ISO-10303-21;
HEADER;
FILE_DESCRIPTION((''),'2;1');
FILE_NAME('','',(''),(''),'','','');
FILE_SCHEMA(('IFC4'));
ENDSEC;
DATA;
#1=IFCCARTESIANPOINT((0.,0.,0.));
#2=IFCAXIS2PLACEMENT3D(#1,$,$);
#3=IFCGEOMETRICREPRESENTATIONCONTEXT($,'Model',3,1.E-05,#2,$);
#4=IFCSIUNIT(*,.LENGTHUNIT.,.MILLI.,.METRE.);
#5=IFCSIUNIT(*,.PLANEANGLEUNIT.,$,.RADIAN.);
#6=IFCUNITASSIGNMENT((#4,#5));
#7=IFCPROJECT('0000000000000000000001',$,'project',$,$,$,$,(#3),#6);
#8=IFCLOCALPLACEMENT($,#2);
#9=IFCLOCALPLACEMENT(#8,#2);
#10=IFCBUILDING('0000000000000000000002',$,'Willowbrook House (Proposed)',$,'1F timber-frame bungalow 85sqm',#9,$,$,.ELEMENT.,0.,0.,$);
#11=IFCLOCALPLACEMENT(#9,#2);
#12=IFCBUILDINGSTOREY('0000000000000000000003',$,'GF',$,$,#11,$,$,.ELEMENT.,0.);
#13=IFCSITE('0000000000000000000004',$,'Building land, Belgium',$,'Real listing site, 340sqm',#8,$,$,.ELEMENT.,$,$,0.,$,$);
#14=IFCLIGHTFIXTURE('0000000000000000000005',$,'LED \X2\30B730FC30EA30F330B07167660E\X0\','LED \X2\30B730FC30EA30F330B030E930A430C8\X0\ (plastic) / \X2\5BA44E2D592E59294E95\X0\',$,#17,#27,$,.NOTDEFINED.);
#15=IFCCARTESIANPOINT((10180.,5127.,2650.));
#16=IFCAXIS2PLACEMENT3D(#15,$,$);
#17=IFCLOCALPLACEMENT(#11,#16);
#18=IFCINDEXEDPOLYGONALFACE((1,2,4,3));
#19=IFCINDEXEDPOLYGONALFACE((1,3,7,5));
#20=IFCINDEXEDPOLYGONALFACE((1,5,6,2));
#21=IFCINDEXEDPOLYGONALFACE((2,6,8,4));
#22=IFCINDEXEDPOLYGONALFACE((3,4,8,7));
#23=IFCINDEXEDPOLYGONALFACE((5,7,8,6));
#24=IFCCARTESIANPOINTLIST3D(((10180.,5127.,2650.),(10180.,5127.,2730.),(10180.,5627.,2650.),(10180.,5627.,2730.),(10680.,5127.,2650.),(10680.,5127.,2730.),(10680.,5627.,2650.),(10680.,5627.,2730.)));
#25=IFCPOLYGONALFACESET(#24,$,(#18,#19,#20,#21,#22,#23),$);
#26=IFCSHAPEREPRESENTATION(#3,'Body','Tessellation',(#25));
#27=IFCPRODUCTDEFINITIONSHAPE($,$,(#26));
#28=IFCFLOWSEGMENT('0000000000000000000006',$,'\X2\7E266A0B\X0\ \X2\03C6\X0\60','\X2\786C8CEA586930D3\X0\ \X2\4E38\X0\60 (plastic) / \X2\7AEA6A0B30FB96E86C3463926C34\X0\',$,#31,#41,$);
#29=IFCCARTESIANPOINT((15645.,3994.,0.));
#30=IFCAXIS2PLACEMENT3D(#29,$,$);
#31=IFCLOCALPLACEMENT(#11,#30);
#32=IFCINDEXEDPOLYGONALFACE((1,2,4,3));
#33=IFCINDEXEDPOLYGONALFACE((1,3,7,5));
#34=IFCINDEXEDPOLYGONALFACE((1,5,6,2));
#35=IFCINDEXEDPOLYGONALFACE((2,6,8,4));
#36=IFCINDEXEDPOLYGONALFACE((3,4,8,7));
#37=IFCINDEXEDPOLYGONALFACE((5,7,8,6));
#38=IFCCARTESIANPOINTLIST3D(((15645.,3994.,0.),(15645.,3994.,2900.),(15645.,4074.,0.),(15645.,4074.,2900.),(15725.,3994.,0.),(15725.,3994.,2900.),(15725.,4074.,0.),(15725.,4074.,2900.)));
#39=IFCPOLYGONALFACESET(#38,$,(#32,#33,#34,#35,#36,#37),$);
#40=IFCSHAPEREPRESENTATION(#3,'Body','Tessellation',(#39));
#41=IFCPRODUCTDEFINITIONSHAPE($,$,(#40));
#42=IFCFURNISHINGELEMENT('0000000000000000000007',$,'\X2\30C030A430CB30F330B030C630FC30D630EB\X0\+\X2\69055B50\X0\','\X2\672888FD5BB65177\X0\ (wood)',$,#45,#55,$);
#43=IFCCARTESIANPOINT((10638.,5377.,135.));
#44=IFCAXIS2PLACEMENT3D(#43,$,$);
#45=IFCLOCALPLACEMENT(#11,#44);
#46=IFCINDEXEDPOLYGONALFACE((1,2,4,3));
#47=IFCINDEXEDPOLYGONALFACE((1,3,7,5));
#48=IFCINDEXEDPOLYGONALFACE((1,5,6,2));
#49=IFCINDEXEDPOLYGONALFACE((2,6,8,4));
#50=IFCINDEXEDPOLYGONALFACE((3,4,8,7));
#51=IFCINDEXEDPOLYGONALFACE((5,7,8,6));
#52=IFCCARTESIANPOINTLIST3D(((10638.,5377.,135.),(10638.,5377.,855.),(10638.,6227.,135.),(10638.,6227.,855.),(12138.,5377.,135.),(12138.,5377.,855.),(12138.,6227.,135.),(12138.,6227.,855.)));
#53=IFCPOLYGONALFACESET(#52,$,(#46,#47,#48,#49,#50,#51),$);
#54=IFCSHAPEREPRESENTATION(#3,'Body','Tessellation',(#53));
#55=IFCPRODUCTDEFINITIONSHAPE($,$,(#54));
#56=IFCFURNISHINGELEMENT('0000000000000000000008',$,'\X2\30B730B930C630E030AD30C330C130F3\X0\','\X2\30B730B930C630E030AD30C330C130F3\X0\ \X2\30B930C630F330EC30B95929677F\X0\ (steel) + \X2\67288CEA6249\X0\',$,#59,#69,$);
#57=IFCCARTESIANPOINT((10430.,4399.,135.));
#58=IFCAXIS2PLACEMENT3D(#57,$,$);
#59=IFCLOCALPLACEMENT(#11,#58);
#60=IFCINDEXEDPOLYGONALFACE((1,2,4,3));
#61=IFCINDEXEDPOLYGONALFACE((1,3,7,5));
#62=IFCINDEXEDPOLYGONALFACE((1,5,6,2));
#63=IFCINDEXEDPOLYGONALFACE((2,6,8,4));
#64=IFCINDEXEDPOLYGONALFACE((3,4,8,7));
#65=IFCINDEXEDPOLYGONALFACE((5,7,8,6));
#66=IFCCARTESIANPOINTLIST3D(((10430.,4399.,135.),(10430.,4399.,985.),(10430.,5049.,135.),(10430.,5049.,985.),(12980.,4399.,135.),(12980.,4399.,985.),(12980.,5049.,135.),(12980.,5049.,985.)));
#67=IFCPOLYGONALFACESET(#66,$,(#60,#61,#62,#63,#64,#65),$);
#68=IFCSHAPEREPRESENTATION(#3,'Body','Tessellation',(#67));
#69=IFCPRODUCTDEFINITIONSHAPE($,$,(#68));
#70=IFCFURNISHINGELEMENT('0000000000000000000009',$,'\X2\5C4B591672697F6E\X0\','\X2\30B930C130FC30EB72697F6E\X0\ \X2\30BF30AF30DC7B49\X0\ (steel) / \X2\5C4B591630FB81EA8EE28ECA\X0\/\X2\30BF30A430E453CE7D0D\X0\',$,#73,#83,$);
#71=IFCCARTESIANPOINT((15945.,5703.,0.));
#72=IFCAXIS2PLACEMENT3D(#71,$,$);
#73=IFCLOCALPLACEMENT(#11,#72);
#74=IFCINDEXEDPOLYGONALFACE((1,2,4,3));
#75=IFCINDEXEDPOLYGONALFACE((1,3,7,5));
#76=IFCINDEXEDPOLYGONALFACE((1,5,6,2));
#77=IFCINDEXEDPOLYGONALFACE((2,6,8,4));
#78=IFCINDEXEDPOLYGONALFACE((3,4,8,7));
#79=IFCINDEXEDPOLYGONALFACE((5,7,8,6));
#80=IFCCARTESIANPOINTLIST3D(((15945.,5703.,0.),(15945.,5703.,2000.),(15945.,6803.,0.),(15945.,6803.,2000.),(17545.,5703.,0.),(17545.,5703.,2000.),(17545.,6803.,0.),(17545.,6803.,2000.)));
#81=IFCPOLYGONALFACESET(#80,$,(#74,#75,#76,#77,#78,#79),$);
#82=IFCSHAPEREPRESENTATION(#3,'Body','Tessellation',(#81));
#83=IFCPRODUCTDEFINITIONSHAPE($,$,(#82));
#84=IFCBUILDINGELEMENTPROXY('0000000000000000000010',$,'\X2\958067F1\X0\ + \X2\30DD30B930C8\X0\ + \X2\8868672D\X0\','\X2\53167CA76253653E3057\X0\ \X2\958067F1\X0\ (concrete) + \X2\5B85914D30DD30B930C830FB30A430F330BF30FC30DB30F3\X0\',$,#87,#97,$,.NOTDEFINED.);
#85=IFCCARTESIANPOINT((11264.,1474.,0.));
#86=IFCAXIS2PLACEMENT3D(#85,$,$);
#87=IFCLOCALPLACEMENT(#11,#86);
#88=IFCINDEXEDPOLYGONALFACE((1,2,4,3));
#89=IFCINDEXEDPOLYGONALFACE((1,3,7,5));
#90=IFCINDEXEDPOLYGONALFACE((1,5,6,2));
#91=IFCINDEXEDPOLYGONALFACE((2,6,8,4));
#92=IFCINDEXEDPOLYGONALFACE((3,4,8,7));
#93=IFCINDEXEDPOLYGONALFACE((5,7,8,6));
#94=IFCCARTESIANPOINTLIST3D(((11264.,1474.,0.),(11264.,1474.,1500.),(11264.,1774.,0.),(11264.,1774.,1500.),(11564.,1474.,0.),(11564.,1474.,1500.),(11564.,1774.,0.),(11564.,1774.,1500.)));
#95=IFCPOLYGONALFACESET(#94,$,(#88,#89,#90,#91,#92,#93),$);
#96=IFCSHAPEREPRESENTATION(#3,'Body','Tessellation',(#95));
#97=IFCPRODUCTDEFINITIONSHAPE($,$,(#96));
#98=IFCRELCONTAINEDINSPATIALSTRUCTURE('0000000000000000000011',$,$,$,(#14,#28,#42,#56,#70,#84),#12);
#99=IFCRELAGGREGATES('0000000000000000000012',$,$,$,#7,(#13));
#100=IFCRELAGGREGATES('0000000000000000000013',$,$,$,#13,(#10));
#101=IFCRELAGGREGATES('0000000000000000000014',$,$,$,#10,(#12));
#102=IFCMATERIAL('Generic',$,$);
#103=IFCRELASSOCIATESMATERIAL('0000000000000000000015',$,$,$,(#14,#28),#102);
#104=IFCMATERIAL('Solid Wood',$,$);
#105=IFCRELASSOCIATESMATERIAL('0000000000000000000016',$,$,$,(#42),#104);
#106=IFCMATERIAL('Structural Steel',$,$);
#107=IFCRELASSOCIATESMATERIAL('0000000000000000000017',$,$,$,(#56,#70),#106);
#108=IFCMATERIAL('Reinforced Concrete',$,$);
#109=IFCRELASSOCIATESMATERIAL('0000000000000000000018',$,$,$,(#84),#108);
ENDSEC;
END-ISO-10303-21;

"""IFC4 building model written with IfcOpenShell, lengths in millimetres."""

from ifc_helpers import new_model, si_unit, frame, frame_2d, origin, place, context, project, spatial, rectangle, extrude, material, element, save


model = new_model("IFC4")

# Units and contexts
model_context = context("Model", 3, precision=1e-05, world=origin())
ifc_project = project(units=[si_unit("LENGTHUNIT", "METRE", prefix="MILLI"), si_unit("PLANEANGLEUNIT", "RADIAN")], contexts=[model_context])

# Site, building, storey
site_placement = place(None, origin())
site = spatial("IfcSite", under=ifc_project, at=site_placement, Name="Building land, Belgium", ObjectType="Real listing site, 340sqm", CompositionType="ELEMENT", RefElevation=0.0)
building_placement = place(site_placement, origin())
building = spatial("IfcBuilding", under=site, at=building_placement, Name="Willowbrook House (Proposed)", ObjectType="1F timber-frame bungalow 85sqm", CompositionType="ELEMENT", ElevationOfRefHeight=0.0, ElevationOfTerrain=0.0)
storey_placement = place(building_placement, origin())
storey = spatial("IfcBuildingStorey", under=building, at=storey_placement, Name="GF", CompositionType="ELEMENT", Elevation=0.0)

# Shared definitions
ifc_material_1 = material(Name="Solid Wood")

# Shared definitions
ifc_material_2 = material(Name="Structural Steel")

# Shared definitions
ifc_material_3 = material(Name="Reinforced Concrete")

# Shared definitions
ifc_material_4 = material(Name="Generic")

# Light fixture
light_fixture_placement = place(storey_placement, frame((10180.0, 5127.0, 2650.0)))
element("IfcLightFixture", 1, at=light_fixture_placement, inside=storey, material=ifc_material_4, Name="LED シーリング照明", Description="LED シーリングライト (plastic) / 室中央天井", PredefinedType="NOTDEFINED", context=model_context, shape_type="SweptSolid", body=[
    extrude(rectangle(XDim=500.0, YDim=500.0, at=frame_2d((250.0, 250.0))), frame((10180.0, 5127.0, 2650.0)), (0.0, 0.0, 1.0), 80.0),
])

# Flow segment
flow_segment_placement = place(storey_placement, frame((15645.0, 3994.0, 0.0)))
element("IfcFlowSegment", 2, at=flow_segment_placement, inside=storey, material=ifc_material_4, Name="縦樋 φ60", Description="硬質塩ビ 丸60 (plastic) / 竪樋・雨水排水", context=model_context, shape_type="SweptSolid", body=[
    extrude(rectangle(XDim=80.0, YDim=80.0, at=frame_2d((40.0, 40.0))), frame((15645.0, 3994.0, 0.0)), (0.0, 0.0, 1.0), 2900.0),
])

# Furnishing elements
furnishing_1_placement = place(storey_placement, frame((10638.0, 5377.0, 135.0)))
element("IfcFurnishingElement", 3, at=furnishing_1_placement, inside=storey, material=ifc_material_1, Name="ダイニングテーブル+椅子", Description="木製家具 (wood)", context=model_context, shape_type="SweptSolid", body=[
    extrude(rectangle(XDim=1500.0, YDim=850.0, at=frame_2d((750.0, 425.0))), frame((10638.0, 5377.0, 135.0)), (0.0, 0.0, 1.0), 720.0),
])
furnishing_2_placement = place(storey_placement, frame((10430.0, 4399.0, 135.0)))
element("IfcFurnishingElement", 4, at=furnishing_2_placement, inside=storey, material=ifc_material_2, Name="システムキッチン", Description="システムキッチン ステンレス天板 (steel) + 木質扉", context=model_context, shape_type="SweptSolid", body=[
    extrude(rectangle(XDim=2550.0, YDim=650.0, at=frame_2d((1275.0, 325.0))), frame((10430.0, 4399.0, 135.0)), (0.0, 0.0, 1.0), 850.0),
])
furnishing_3_placement = place(storey_placement, frame((15945.0, 5703.0, 0.0)))
element("IfcFurnishingElement", 5, at=furnishing_3_placement, inside=storey, material=ifc_material_2, Name="屋外物置", Description="スチール物置 タクボ等 (steel) / 屋外・自転車/タイヤ収納", context=model_context, shape_type="SweptSolid", body=[
    extrude(rectangle(XDim=1600.0, YDim=1100.0, at=frame_2d((800.0, 550.0))), frame((15945.0, 5703.0, 0.0)), (0.0, 0.0, 1.0), 2000.0),
])

# Building element proxy
proxy_placement = place(storey_placement, frame((11264.0, 1474.0, 0.0)))
element("IfcBuildingElementProxy", 6, at=proxy_placement, inside=storey, material=ifc_material_3, Name="門柱 + ポスト + 表札", Description="化粧打放し 門柱 (concrete) + 宅配ポスト・インターホン", PredefinedType="NOTDEFINED", context=model_context, shape_type="SweptSolid", body=[
    extrude(rectangle(XDim=300.0, YDim=300.0, at=frame_2d((150.0, 150.0))), frame((11264.0, 1474.0, 0.0)), (0.0, 0.0, 1.0), 1500.0),
])

save(model, "model.ifc")
